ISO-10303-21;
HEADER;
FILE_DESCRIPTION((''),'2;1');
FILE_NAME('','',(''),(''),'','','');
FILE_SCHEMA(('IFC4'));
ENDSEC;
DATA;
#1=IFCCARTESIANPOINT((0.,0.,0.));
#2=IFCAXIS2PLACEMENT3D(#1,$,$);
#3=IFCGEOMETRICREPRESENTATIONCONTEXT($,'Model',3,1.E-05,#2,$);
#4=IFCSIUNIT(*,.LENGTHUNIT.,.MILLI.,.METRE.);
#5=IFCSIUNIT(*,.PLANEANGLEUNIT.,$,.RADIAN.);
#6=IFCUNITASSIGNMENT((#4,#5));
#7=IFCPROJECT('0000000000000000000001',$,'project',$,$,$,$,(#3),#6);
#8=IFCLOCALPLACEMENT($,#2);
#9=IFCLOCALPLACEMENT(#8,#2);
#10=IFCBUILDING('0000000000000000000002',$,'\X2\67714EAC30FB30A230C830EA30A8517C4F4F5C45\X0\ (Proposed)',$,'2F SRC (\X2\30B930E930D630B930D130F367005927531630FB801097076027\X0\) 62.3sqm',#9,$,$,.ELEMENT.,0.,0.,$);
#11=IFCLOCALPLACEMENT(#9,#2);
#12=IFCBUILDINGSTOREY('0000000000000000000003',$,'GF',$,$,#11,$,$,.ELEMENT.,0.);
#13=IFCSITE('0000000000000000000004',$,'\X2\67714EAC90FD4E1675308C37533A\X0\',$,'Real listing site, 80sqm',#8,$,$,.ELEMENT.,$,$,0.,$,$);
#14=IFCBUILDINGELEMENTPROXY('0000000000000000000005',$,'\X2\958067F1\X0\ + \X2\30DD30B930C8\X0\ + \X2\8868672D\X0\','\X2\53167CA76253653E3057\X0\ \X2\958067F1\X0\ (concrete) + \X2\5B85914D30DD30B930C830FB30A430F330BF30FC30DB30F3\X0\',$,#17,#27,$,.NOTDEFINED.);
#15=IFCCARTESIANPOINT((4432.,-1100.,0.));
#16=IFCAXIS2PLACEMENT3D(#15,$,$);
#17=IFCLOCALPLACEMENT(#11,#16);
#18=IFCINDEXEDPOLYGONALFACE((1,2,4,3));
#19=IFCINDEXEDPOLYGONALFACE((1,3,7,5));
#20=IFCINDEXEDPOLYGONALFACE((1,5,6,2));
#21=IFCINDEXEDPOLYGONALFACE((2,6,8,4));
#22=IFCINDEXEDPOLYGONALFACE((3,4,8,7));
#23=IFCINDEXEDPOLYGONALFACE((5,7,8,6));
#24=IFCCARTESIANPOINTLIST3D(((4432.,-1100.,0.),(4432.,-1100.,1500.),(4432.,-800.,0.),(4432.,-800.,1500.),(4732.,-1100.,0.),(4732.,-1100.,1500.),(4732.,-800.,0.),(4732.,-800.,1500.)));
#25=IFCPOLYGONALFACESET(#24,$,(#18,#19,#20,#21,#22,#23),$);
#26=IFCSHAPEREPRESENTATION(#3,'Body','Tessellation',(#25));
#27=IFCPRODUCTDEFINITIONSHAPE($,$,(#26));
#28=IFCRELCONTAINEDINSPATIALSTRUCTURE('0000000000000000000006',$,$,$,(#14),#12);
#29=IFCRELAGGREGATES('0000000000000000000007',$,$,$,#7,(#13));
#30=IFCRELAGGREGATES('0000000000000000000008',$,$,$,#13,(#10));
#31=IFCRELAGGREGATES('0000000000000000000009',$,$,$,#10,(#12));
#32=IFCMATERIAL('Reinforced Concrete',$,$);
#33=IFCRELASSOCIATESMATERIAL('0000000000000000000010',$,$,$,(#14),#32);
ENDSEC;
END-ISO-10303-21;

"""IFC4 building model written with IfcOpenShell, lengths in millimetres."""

from ifc_helpers import new_model, si_unit, frame, frame_2d, origin, place, context, project, spatial, rectangle, extrude, material, element, save


model = new_model("IFC4")

# Units and contexts
model_context = context("Model", 3, precision=1e-05, world=origin())
ifc_project = project(units=[si_unit("LENGTHUNIT", "METRE", prefix="MILLI"), si_unit("PLANEANGLEUNIT", "RADIAN")], contexts=[model_context])

# Site, building, storey
site_placement = place(None, origin())
site = spatial("IfcSite", under=ifc_project, at=site_placement, Name="東京都世田谷区", ObjectType="Real listing site, 80sqm", CompositionType="ELEMENT", RefElevation=0.0)
building_placement = place(site_placement, origin())
building = spatial("IfcBuilding", under=site, at=building_placement, Name="東京・アトリエ兼住居 (Proposed)", ObjectType="2F SRC (スラブスパン最大化・耐震性) 62.3sqm", CompositionType="ELEMENT", ElevationOfRefHeight=0.0, ElevationOfTerrain=0.0)
storey_placement = place(building_placement, origin())
storey = spatial("IfcBuildingStorey", under=building, at=storey_placement, Name="GF", CompositionType="ELEMENT", Elevation=0.0)

# Shared definitions
ifc_material_1 = material(Name="Reinforced Concrete")

# Building element proxy
proxy_placement = place(storey_placement, frame((4432.0, -1100.0, 0.0)))
element("IfcBuildingElementProxy", 1, at=proxy_placement, inside=storey, material=ifc_material_1, Name="門柱 + ポスト + 表札", Description="化粧打放し 門柱 (concrete) + 宅配ポスト・インターホン", PredefinedType="NOTDEFINED", context=model_context, shape_type="SweptSolid", body=[
    extrude(rectangle(XDim=300.0, YDim=300.0, at=frame_2d((150.0, 150.0))), frame((4432.0, -1100.0, 0.0)), (0.0, 0.0, 1.0), 1500.0),
])

save(model, "model.ifc")
